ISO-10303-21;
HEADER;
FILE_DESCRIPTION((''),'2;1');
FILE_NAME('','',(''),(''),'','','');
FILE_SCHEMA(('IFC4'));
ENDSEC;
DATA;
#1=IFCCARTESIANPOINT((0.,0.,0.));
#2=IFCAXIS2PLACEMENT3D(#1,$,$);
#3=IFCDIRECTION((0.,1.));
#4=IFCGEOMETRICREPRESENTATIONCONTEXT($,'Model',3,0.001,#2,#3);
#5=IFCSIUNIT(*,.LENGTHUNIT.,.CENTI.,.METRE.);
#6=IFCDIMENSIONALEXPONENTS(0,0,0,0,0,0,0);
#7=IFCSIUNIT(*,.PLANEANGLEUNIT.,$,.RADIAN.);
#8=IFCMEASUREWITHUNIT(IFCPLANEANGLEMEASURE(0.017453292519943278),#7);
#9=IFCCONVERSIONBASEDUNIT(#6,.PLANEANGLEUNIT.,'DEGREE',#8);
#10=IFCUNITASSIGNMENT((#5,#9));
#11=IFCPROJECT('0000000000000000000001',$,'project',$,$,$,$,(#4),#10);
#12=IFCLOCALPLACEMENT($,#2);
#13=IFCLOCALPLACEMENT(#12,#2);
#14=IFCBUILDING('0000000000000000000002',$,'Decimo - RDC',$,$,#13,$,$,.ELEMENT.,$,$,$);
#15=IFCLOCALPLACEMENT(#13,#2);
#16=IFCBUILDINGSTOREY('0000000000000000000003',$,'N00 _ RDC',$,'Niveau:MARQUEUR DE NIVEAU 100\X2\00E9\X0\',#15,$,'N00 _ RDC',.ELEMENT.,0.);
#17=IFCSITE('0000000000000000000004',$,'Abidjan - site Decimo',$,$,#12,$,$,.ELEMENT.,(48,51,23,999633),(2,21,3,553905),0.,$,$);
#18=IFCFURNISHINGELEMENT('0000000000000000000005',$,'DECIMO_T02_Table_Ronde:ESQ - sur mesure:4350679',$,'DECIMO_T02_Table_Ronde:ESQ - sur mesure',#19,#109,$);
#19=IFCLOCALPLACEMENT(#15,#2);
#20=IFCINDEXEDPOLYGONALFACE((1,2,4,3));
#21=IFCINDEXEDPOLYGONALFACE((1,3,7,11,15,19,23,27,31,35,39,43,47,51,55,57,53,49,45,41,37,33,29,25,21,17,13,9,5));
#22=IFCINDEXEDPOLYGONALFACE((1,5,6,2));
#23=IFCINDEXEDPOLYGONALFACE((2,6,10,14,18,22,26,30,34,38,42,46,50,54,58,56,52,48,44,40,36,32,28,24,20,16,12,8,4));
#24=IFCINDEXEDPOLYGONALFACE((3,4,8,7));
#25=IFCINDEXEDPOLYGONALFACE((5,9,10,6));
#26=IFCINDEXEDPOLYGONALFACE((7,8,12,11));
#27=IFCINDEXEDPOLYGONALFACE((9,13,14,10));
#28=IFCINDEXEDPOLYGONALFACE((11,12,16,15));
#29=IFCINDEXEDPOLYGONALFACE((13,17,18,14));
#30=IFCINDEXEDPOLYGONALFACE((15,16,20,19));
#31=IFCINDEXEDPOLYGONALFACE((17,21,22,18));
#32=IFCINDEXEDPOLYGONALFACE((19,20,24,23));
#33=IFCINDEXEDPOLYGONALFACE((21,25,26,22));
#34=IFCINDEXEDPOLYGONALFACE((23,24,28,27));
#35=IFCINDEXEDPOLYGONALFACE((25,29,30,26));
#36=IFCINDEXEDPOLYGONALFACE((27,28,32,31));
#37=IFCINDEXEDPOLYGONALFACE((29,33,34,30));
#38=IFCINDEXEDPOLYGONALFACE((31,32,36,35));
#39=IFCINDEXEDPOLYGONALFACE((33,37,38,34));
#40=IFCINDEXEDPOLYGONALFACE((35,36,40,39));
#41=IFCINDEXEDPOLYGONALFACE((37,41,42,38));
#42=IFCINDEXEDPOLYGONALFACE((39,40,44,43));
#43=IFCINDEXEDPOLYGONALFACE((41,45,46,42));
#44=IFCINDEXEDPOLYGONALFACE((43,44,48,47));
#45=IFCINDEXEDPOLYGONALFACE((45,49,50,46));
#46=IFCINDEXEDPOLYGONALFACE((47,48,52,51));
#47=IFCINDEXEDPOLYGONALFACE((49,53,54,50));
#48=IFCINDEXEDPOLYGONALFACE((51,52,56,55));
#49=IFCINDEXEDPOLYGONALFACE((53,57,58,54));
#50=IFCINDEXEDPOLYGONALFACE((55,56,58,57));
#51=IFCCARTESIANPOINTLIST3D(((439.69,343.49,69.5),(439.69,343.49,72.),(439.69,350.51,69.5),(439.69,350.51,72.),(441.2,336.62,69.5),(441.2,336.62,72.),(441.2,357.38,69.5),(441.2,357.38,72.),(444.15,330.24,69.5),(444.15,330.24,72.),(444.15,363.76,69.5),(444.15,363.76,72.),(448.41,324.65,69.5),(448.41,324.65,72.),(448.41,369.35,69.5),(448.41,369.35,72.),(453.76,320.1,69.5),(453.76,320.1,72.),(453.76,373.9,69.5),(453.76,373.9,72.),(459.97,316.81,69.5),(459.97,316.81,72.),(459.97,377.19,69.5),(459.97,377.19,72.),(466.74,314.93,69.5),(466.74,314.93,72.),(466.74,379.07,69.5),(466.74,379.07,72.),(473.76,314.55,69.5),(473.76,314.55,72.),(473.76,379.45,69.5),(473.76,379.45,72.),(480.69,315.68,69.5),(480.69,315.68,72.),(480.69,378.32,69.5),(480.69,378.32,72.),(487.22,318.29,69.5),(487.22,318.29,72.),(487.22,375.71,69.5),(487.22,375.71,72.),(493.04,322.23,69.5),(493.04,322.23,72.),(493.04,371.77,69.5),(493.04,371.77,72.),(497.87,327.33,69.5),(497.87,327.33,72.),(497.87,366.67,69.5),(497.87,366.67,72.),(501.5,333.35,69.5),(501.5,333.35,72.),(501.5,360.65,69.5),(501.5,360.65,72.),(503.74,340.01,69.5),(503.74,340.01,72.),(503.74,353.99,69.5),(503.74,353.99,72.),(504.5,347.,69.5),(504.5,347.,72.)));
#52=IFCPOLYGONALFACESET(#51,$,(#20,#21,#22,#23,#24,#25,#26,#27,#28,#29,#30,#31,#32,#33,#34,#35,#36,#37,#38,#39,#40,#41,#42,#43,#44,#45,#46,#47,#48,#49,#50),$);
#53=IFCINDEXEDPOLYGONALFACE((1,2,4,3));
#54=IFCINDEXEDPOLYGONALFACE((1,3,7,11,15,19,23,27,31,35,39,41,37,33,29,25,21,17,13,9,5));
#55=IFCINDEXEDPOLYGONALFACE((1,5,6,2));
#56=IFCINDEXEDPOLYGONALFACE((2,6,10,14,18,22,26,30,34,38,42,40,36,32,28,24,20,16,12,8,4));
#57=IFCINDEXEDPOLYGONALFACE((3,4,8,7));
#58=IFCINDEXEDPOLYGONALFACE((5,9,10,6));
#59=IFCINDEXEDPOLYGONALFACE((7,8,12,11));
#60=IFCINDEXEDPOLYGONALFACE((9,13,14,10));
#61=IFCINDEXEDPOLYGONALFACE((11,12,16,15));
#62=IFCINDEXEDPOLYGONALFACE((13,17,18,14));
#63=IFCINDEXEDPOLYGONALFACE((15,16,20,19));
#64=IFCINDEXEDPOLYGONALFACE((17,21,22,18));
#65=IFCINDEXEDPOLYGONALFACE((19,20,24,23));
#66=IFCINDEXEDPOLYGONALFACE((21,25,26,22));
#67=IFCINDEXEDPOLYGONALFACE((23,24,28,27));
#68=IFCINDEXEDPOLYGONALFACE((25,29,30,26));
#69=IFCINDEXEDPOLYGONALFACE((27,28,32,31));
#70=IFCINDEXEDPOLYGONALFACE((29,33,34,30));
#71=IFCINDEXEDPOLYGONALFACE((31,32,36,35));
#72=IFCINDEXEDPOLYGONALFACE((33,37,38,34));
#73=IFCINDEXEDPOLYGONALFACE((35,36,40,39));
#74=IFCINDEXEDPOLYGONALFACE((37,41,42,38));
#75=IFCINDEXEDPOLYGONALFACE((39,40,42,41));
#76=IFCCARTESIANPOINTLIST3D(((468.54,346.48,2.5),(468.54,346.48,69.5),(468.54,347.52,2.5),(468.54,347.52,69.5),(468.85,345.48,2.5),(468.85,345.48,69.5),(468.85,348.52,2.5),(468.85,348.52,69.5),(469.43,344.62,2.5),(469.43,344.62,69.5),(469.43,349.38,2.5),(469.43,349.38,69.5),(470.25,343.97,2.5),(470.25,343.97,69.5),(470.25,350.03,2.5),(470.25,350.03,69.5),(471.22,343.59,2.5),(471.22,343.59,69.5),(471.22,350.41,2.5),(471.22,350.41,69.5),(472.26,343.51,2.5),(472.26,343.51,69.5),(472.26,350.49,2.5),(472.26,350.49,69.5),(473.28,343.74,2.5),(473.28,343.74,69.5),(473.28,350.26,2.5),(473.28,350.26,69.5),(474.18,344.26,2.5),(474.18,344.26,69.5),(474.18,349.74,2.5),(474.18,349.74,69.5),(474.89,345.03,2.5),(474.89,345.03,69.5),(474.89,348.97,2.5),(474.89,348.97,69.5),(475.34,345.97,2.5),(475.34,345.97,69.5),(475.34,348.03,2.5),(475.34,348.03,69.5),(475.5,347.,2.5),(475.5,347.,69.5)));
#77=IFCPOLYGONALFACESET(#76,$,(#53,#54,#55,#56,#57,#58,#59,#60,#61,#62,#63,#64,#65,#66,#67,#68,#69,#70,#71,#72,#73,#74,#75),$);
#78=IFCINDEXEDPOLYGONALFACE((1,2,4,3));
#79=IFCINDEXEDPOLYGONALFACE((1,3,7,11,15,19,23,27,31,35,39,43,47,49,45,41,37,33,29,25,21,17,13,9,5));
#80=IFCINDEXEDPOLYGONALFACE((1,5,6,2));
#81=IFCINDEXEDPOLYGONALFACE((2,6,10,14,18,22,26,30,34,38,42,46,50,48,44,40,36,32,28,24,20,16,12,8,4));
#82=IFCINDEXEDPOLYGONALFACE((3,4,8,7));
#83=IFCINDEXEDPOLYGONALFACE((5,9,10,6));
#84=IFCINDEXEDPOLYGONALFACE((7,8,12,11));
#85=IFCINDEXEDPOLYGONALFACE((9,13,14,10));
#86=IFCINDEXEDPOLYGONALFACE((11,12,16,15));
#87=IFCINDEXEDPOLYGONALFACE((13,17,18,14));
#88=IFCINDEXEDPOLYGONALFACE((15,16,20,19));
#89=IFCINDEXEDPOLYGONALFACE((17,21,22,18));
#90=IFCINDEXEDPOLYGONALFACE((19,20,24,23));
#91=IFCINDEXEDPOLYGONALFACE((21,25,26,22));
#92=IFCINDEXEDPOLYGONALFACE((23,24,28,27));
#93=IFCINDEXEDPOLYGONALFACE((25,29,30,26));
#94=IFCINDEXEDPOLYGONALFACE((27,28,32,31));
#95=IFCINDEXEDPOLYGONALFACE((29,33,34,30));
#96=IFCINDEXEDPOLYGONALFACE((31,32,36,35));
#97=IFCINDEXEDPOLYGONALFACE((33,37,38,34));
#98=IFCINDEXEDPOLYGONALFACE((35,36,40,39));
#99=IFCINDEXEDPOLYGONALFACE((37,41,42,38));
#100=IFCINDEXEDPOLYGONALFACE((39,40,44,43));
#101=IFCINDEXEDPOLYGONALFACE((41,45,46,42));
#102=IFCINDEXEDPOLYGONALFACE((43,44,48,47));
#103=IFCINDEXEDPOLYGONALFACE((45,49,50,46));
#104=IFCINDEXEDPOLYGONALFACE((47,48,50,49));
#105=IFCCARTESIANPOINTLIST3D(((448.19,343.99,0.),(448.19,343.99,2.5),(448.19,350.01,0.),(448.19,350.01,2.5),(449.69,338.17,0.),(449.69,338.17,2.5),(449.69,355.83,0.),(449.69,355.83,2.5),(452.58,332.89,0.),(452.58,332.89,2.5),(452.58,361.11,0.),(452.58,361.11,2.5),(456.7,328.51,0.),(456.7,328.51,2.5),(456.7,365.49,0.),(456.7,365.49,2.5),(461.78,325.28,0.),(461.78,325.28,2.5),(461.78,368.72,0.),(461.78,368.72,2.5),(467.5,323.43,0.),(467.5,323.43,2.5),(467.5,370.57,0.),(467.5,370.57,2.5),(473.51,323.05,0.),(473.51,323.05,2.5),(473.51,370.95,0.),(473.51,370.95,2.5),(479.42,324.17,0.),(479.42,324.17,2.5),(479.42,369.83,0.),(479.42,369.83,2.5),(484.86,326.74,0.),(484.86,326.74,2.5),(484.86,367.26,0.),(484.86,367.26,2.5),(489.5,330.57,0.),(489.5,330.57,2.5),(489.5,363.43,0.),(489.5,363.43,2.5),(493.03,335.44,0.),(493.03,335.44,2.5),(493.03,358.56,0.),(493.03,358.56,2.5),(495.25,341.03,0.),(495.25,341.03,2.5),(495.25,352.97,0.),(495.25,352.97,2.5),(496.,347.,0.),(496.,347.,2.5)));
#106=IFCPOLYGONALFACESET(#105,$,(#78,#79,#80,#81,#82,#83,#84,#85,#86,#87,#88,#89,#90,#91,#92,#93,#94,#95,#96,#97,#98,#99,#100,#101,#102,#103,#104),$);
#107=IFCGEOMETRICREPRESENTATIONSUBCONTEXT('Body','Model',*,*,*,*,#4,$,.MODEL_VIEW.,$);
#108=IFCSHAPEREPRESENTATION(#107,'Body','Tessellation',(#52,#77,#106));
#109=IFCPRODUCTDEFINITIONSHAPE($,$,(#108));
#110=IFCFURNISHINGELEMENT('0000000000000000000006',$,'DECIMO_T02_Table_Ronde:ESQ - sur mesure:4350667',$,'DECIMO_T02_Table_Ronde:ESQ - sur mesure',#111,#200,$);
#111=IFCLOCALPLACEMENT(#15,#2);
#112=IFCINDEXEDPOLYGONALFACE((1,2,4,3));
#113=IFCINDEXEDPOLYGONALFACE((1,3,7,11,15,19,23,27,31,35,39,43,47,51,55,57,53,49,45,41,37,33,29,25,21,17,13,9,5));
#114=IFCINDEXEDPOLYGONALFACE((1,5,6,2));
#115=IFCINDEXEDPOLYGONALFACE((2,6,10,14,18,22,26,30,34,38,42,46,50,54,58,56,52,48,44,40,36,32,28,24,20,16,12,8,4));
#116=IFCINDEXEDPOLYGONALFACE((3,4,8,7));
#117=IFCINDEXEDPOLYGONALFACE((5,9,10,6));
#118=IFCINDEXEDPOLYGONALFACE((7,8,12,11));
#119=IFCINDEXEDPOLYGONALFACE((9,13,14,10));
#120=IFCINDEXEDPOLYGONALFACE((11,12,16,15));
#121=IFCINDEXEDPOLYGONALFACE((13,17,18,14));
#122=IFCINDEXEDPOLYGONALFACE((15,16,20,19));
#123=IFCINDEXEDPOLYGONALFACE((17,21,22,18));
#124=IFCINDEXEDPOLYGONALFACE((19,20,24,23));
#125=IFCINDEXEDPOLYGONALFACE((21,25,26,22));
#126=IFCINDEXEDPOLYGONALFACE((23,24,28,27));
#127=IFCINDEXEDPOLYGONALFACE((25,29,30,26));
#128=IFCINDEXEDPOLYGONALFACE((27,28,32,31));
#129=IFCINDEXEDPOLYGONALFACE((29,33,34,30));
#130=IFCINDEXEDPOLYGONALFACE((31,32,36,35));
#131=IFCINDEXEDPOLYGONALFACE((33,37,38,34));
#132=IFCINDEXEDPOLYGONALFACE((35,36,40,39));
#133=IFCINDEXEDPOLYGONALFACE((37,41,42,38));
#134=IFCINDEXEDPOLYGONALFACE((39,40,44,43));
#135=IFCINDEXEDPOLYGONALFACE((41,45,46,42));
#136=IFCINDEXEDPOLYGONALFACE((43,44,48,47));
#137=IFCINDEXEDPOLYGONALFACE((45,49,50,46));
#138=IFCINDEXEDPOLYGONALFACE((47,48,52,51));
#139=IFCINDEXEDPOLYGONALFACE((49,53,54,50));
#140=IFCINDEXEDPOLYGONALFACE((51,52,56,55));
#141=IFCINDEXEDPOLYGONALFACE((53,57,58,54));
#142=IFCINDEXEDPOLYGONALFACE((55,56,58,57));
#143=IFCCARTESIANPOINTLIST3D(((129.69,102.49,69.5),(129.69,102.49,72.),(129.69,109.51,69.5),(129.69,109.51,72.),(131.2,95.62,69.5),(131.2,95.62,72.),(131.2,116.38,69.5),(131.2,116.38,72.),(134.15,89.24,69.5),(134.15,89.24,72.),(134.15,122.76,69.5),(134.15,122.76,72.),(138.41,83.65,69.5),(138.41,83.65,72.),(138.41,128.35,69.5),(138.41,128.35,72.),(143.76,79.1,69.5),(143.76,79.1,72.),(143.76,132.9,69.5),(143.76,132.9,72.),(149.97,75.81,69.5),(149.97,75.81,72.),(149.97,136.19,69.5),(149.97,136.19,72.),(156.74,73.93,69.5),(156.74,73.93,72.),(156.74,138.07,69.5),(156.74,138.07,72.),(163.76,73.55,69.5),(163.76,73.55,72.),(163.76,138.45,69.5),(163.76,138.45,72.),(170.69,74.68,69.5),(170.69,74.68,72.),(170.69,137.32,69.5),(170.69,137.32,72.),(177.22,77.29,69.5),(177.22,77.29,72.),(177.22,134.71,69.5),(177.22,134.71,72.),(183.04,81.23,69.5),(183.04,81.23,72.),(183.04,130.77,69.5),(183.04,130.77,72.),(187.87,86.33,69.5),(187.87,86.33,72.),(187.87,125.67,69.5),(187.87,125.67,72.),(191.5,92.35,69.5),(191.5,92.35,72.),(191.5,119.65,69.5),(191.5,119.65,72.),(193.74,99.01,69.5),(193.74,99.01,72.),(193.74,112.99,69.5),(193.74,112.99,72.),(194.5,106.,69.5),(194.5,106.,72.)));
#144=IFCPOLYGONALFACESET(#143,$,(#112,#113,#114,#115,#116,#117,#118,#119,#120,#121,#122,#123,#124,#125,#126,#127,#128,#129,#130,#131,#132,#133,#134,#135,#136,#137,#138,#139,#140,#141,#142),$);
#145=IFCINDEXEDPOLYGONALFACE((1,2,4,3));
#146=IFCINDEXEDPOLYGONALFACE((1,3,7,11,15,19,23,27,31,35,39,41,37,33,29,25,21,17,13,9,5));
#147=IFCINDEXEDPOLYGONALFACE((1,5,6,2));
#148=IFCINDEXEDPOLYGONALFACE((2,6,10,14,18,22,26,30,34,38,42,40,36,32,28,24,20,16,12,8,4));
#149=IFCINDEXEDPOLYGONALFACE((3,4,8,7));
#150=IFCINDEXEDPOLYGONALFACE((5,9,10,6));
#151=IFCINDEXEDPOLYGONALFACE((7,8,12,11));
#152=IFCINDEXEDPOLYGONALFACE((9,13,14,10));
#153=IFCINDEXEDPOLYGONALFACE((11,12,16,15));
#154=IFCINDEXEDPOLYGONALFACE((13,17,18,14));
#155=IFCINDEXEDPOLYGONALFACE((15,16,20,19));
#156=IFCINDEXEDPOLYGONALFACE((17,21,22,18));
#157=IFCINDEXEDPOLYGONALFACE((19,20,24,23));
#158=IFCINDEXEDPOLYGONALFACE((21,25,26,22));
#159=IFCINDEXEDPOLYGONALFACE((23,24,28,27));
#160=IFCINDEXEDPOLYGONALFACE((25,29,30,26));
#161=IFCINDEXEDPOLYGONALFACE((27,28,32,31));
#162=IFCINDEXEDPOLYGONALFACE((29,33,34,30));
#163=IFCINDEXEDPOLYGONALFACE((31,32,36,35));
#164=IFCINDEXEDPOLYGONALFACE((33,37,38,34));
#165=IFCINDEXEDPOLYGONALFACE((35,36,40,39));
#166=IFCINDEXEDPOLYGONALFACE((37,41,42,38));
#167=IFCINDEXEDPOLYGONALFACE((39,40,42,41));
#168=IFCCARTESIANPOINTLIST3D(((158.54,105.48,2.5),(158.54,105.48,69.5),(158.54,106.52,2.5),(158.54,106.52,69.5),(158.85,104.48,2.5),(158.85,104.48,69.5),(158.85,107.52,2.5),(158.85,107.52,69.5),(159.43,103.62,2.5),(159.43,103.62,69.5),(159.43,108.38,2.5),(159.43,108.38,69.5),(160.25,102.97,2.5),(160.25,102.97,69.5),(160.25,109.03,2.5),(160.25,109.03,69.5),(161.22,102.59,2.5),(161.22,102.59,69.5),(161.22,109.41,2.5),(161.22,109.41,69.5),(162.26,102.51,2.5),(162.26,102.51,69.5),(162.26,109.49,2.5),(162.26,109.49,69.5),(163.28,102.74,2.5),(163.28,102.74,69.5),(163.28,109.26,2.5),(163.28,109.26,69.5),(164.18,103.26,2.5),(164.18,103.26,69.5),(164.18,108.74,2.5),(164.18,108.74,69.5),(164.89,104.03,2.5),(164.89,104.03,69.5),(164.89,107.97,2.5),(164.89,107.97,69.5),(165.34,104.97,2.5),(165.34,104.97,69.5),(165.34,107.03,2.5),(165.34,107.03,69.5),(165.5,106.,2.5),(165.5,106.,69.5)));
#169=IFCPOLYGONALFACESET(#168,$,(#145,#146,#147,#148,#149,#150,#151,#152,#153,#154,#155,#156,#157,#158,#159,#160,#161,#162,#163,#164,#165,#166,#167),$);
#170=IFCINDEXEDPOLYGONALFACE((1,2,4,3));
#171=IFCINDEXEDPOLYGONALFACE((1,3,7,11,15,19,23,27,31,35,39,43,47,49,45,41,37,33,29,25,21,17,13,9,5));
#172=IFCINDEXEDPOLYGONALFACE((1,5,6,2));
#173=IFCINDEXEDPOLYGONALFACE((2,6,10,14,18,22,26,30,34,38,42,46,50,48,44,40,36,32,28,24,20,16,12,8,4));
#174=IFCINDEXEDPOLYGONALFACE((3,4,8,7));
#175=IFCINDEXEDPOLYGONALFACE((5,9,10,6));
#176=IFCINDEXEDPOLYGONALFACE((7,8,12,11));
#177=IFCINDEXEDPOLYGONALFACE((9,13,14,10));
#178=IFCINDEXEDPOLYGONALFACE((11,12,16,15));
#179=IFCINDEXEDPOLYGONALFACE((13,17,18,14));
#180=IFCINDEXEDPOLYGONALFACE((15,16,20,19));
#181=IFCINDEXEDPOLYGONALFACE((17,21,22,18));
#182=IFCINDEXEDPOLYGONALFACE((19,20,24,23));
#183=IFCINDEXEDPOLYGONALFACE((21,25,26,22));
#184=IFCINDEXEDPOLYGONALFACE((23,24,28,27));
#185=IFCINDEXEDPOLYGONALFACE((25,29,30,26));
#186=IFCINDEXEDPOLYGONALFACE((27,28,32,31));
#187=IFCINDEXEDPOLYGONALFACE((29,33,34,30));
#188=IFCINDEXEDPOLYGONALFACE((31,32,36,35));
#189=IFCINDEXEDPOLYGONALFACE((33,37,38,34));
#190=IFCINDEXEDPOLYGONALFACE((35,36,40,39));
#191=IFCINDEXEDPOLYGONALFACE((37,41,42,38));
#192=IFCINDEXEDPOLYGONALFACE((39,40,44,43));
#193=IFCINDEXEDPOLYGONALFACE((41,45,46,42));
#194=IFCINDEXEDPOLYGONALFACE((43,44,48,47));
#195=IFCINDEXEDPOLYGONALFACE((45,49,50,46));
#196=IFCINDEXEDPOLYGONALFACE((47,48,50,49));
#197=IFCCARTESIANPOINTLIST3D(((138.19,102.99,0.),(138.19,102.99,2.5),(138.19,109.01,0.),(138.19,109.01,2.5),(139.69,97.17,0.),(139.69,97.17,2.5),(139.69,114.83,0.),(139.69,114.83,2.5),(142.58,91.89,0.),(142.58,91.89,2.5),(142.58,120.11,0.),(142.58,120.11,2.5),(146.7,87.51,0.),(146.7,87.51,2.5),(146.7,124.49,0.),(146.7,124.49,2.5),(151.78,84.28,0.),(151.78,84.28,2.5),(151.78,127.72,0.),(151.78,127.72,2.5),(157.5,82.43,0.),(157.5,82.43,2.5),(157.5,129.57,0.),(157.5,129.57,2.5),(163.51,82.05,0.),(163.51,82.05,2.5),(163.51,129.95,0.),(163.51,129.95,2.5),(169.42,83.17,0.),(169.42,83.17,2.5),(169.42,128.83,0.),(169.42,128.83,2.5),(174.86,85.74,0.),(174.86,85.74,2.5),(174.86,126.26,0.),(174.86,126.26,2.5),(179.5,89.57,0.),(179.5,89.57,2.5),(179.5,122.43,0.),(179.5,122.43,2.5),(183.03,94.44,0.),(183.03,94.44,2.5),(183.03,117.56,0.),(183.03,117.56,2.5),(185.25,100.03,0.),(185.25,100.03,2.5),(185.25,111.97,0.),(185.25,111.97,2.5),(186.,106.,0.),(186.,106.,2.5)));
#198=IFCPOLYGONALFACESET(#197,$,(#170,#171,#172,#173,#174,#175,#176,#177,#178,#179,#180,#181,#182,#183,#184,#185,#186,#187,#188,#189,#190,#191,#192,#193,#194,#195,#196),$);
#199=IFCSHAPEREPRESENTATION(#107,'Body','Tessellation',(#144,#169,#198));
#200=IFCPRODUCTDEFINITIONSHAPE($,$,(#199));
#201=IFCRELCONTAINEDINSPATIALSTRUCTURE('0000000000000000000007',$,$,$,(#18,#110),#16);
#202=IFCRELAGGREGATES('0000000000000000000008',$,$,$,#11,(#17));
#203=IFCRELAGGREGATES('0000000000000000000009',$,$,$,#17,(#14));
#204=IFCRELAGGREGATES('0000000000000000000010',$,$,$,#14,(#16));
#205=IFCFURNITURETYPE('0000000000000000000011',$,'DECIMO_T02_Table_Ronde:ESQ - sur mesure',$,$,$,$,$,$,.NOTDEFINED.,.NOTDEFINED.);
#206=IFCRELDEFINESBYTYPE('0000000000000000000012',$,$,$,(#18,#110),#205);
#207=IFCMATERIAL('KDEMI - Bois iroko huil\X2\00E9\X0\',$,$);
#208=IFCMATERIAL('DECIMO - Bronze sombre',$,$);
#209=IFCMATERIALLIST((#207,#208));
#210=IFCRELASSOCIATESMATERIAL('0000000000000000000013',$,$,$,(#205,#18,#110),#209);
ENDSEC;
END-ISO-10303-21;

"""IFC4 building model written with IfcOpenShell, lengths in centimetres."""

from ifc_helpers import new_model, entity, si_unit, converted_unit, direction, frame, frame_2d, origin, place, context, subcontext, project, spatial, circle, extrude, source, transform, mapped, material, material_list, type_object, type_shapes, element, save


model = new_model("IFC4")

# Units and contexts
model_context = context("Model", 3, precision=0.001, world=origin(), true_north=direction((0.0, 1.0)))
body_context = subcontext(model_context, "Body", "Model", "MODEL_VIEW")
ifc_project = project(units=[si_unit("LENGTHUNIT", "METRE", prefix="CENTI"), converted_unit("PLANEANGLEUNIT", "DEGREE", entity("IfcPlaneAngleMeasure", 0.017453292519943278), si_unit("PLANEANGLEUNIT", "RADIAN"), dimensions=[0, 0, 0, 0, 0, 0, 0])], contexts=[model_context])

# Site, building, storey
site_placement = place(None, origin())
site = spatial("IfcSite", under=ifc_project, at=site_placement, Name="Abidjan - site Decimo", CompositionType="ELEMENT", RefLatitude=(48, 51, 23, 999633), RefLongitude=(2, 21, 3, 553905), RefElevation=0.0)
building_placement = place(site_placement, origin())
building = spatial("IfcBuilding", under=site, at=building_placement, Name="Decimo - RDC", CompositionType="ELEMENT")
storey_placement = place(building_placement, origin())
storey = spatial("IfcBuildingStorey", under=building, at=storey_placement, Name="N00 _ RDC", ObjectType="Niveau:MARQUEUR DE NIVEAU 100é", LongName="N00 _ RDC", CompositionType="ELEMENT", Elevation=0.0)

# Furnishing elements
ifc_material_1 = material(Name="KDEMI - Bois iroko huilé")
ifc_material_2 = material(Name="DECIMO - Bronze sombre")
ifc_material_list_1 = material_list([ifc_material_1, ifc_material_2])
furniture_type_1 = type_object("IfcFurnitureType", Name="DECIMO_T02_Table_Ronde:ESQ - sur mesure", AssemblyPlace="NOTDEFINED", material=ifc_material_list_1)
shared_shape_1 = source(origin(), body_context, "Body", "SweptSolid", [
    extrude(circle(Radius=32.5, at=frame_2d((0.0, 0.0), x_axis=(1.0, 0.0))), frame((0.0, 0.0, 69.5)), (0.0, 0.0, 1.0), 2.5),
    extrude(circle(Radius=3.5, at=frame_2d((0.0, 0.0), x_axis=(1.0, 0.0))), frame((0.0, 0.0, 2.5)), (0.0, 0.0, 1.0), 67.0),
    extrude(circle(Radius=24.0, at=frame_2d((0.0, 0.0), x_axis=(1.0, 0.0))), origin(), (0.0, 0.0, 1.0), 2.5),
])
type_shapes(furniture_type_1, [shared_shape_1])
for number, where, z_axis, x_axis, name in (
    (1, (472.0, 347.0, 0.0), (0.0, 0.0, 1.0), (1.0, 0.0, 0.0), "DECIMO_T02_Table_Ronde:ESQ - sur mesure:4350679"),
):
    element("IfcFurnishingElement", number, at=place(storey_placement, frame(where, z_axis=z_axis, x_axis=x_axis)), inside=storey, type_object=furniture_type_1, material=ifc_material_list_1, Name=name, ObjectType="DECIMO_T02_Table_Ronde:ESQ - sur mesure", context=body_context, shape_type="MappedRepresentation", body=[
        mapped(shared_shape_1, transform((0.0, 0.0, 0.0), scale=1.0)),
    ])
for number, where, name in (
    (2, (162.0, 106.0, 0.0), "DECIMO_T02_Table_Ronde:ESQ - sur mesure:4350667"),
):
    element("IfcFurnishingElement", number, at=place(storey_placement, frame(where)), inside=storey, type_object=furniture_type_1, material=ifc_material_list_1, Name=name, ObjectType="DECIMO_T02_Table_Ronde:ESQ - sur mesure", context=body_context, shape_type="MappedRepresentation", body=[
        mapped(shared_shape_1, transform((0.0, 0.0, 0.0), scale=1.0)),
    ])

save(model, "model.ifc")
